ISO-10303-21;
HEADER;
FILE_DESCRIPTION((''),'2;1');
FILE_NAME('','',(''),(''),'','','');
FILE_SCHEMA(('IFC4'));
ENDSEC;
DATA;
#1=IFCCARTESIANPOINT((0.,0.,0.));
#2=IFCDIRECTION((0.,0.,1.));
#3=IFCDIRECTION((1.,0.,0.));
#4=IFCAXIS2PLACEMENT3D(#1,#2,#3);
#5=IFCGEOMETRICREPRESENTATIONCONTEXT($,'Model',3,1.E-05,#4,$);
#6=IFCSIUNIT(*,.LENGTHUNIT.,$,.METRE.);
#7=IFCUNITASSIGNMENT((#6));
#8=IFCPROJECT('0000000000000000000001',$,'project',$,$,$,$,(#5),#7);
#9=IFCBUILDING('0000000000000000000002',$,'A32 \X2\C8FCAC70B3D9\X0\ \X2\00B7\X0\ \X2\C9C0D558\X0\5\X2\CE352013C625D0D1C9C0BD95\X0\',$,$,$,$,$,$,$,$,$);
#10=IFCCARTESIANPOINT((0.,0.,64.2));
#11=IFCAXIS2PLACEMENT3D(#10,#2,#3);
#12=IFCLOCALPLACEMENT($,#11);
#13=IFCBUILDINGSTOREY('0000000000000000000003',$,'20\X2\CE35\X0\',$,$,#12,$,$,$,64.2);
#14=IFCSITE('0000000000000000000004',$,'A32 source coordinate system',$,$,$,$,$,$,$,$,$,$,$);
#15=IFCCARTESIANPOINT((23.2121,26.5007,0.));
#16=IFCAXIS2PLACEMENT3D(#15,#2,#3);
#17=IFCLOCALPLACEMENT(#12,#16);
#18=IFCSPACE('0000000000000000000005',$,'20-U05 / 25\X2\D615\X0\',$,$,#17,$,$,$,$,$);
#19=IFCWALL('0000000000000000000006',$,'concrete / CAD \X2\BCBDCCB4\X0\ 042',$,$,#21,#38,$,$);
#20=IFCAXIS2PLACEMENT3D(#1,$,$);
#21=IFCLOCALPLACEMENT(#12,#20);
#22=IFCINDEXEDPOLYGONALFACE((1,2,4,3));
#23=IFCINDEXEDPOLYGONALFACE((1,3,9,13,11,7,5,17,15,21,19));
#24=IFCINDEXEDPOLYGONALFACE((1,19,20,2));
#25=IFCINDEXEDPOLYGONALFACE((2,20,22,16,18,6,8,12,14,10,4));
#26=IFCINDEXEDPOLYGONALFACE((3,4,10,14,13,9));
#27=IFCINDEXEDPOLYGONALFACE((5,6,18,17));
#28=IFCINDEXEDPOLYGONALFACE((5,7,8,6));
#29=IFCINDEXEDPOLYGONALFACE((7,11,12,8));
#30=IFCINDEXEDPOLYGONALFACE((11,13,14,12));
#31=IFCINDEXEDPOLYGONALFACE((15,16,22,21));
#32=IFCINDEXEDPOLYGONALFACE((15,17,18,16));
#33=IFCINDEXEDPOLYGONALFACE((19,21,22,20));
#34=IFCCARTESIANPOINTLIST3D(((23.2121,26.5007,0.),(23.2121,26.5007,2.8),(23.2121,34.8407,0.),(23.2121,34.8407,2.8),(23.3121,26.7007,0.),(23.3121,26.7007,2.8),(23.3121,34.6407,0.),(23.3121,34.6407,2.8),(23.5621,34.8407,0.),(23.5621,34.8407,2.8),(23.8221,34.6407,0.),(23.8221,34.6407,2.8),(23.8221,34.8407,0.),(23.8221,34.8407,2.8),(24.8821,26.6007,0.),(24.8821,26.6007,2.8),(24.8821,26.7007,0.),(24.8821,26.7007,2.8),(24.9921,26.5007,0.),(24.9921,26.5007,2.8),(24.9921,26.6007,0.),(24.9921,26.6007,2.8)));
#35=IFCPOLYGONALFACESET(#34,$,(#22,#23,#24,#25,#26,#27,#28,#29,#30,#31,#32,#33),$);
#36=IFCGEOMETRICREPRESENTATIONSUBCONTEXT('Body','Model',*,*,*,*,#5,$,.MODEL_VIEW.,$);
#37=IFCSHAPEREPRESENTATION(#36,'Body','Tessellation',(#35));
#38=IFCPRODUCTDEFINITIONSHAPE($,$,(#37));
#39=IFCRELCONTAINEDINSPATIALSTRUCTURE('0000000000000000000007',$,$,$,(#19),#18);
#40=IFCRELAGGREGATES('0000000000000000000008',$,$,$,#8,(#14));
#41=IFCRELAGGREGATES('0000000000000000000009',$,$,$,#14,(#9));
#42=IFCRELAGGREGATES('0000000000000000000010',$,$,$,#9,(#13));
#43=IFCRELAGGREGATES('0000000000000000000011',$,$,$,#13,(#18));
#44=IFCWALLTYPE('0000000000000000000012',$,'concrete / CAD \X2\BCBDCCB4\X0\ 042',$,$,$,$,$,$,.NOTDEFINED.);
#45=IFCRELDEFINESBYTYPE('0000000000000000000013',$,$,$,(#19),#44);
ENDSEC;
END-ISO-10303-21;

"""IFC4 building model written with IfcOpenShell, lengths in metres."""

from ifc_helpers import new_model, si_unit, frame, origin, origin_with_axes, place, context, subcontext, project, spatial, polyline, outline, extrude, source, transform, mapped, type_object, type_shapes, element, save


model = new_model("IFC4")

# Units and contexts
model_context = context("Model", 3, precision=1e-05, world=origin_with_axes())
body_context = subcontext(model_context, "Body", "Model", "MODEL_VIEW")
ifc_project = project(units=[si_unit("LENGTHUNIT", "METRE")], contexts=[model_context])

# Site, building, storey, space
site = spatial("IfcSite", under=ifc_project, Name="A32 source coordinate system")
building = spatial("IfcBuilding", under=site, Name="A32 주거동 · 지하5층–옥탑지붕")
storey_placement = place(None, frame((0.0, 0.0, 64.2), z_axis=(0.0, 0.0, 1.0), x_axis=(1.0, 0.0, 0.0)))
storey = spatial("IfcBuildingStorey", under=building, at=storey_placement, Name="20층", Elevation=64.2)
space_1_placement = place(storey_placement, frame((23.2121, 26.5007, 0.0), z_axis=(0.0, 0.0, 1.0), x_axis=(1.0, 0.0, 0.0)))
space_1 = spatial("IfcSpace", under=storey, at=space_1_placement, Name="20-U05 / 25형")

# Wall
wall_type_1 = type_object("IfcWallType", Name="concrete / CAD 벽체 042", PredefinedType="NOTDEFINED")
shared_shape_1 = source(origin(), body_context, "Body", "SweptSolid", [
    extrude(outline(polyline([(0.1, 8.14), (0.1, 0.2), (1.67, 0.2), (1.67, 0.1), (1.78, 0.1), (1.78, 0.0), (0.0, 0.0), (0.0, 8.34), (0.35, 8.34), (0.35, 8.34), (0.61, 8.34), (0.61, 8.14), (0.1, 8.14)])), origin(), (0.0, 0.0, 1.0), 2.8),
])
type_shapes(wall_type_1, [shared_shape_1])
wall_1_placement = place(space_1_placement, origin_with_axes())
element("IfcWall", 1, at=wall_1_placement, inside=space_1, type_object=wall_type_1, Name="concrete / CAD 벽체 042", context=body_context, shape_type="MappedRepresentation", body=[
    mapped(shared_shape_1, transform((0.0, 0.0, 0.0), scale=1.0)),
])

save(model, "model.ifc")
